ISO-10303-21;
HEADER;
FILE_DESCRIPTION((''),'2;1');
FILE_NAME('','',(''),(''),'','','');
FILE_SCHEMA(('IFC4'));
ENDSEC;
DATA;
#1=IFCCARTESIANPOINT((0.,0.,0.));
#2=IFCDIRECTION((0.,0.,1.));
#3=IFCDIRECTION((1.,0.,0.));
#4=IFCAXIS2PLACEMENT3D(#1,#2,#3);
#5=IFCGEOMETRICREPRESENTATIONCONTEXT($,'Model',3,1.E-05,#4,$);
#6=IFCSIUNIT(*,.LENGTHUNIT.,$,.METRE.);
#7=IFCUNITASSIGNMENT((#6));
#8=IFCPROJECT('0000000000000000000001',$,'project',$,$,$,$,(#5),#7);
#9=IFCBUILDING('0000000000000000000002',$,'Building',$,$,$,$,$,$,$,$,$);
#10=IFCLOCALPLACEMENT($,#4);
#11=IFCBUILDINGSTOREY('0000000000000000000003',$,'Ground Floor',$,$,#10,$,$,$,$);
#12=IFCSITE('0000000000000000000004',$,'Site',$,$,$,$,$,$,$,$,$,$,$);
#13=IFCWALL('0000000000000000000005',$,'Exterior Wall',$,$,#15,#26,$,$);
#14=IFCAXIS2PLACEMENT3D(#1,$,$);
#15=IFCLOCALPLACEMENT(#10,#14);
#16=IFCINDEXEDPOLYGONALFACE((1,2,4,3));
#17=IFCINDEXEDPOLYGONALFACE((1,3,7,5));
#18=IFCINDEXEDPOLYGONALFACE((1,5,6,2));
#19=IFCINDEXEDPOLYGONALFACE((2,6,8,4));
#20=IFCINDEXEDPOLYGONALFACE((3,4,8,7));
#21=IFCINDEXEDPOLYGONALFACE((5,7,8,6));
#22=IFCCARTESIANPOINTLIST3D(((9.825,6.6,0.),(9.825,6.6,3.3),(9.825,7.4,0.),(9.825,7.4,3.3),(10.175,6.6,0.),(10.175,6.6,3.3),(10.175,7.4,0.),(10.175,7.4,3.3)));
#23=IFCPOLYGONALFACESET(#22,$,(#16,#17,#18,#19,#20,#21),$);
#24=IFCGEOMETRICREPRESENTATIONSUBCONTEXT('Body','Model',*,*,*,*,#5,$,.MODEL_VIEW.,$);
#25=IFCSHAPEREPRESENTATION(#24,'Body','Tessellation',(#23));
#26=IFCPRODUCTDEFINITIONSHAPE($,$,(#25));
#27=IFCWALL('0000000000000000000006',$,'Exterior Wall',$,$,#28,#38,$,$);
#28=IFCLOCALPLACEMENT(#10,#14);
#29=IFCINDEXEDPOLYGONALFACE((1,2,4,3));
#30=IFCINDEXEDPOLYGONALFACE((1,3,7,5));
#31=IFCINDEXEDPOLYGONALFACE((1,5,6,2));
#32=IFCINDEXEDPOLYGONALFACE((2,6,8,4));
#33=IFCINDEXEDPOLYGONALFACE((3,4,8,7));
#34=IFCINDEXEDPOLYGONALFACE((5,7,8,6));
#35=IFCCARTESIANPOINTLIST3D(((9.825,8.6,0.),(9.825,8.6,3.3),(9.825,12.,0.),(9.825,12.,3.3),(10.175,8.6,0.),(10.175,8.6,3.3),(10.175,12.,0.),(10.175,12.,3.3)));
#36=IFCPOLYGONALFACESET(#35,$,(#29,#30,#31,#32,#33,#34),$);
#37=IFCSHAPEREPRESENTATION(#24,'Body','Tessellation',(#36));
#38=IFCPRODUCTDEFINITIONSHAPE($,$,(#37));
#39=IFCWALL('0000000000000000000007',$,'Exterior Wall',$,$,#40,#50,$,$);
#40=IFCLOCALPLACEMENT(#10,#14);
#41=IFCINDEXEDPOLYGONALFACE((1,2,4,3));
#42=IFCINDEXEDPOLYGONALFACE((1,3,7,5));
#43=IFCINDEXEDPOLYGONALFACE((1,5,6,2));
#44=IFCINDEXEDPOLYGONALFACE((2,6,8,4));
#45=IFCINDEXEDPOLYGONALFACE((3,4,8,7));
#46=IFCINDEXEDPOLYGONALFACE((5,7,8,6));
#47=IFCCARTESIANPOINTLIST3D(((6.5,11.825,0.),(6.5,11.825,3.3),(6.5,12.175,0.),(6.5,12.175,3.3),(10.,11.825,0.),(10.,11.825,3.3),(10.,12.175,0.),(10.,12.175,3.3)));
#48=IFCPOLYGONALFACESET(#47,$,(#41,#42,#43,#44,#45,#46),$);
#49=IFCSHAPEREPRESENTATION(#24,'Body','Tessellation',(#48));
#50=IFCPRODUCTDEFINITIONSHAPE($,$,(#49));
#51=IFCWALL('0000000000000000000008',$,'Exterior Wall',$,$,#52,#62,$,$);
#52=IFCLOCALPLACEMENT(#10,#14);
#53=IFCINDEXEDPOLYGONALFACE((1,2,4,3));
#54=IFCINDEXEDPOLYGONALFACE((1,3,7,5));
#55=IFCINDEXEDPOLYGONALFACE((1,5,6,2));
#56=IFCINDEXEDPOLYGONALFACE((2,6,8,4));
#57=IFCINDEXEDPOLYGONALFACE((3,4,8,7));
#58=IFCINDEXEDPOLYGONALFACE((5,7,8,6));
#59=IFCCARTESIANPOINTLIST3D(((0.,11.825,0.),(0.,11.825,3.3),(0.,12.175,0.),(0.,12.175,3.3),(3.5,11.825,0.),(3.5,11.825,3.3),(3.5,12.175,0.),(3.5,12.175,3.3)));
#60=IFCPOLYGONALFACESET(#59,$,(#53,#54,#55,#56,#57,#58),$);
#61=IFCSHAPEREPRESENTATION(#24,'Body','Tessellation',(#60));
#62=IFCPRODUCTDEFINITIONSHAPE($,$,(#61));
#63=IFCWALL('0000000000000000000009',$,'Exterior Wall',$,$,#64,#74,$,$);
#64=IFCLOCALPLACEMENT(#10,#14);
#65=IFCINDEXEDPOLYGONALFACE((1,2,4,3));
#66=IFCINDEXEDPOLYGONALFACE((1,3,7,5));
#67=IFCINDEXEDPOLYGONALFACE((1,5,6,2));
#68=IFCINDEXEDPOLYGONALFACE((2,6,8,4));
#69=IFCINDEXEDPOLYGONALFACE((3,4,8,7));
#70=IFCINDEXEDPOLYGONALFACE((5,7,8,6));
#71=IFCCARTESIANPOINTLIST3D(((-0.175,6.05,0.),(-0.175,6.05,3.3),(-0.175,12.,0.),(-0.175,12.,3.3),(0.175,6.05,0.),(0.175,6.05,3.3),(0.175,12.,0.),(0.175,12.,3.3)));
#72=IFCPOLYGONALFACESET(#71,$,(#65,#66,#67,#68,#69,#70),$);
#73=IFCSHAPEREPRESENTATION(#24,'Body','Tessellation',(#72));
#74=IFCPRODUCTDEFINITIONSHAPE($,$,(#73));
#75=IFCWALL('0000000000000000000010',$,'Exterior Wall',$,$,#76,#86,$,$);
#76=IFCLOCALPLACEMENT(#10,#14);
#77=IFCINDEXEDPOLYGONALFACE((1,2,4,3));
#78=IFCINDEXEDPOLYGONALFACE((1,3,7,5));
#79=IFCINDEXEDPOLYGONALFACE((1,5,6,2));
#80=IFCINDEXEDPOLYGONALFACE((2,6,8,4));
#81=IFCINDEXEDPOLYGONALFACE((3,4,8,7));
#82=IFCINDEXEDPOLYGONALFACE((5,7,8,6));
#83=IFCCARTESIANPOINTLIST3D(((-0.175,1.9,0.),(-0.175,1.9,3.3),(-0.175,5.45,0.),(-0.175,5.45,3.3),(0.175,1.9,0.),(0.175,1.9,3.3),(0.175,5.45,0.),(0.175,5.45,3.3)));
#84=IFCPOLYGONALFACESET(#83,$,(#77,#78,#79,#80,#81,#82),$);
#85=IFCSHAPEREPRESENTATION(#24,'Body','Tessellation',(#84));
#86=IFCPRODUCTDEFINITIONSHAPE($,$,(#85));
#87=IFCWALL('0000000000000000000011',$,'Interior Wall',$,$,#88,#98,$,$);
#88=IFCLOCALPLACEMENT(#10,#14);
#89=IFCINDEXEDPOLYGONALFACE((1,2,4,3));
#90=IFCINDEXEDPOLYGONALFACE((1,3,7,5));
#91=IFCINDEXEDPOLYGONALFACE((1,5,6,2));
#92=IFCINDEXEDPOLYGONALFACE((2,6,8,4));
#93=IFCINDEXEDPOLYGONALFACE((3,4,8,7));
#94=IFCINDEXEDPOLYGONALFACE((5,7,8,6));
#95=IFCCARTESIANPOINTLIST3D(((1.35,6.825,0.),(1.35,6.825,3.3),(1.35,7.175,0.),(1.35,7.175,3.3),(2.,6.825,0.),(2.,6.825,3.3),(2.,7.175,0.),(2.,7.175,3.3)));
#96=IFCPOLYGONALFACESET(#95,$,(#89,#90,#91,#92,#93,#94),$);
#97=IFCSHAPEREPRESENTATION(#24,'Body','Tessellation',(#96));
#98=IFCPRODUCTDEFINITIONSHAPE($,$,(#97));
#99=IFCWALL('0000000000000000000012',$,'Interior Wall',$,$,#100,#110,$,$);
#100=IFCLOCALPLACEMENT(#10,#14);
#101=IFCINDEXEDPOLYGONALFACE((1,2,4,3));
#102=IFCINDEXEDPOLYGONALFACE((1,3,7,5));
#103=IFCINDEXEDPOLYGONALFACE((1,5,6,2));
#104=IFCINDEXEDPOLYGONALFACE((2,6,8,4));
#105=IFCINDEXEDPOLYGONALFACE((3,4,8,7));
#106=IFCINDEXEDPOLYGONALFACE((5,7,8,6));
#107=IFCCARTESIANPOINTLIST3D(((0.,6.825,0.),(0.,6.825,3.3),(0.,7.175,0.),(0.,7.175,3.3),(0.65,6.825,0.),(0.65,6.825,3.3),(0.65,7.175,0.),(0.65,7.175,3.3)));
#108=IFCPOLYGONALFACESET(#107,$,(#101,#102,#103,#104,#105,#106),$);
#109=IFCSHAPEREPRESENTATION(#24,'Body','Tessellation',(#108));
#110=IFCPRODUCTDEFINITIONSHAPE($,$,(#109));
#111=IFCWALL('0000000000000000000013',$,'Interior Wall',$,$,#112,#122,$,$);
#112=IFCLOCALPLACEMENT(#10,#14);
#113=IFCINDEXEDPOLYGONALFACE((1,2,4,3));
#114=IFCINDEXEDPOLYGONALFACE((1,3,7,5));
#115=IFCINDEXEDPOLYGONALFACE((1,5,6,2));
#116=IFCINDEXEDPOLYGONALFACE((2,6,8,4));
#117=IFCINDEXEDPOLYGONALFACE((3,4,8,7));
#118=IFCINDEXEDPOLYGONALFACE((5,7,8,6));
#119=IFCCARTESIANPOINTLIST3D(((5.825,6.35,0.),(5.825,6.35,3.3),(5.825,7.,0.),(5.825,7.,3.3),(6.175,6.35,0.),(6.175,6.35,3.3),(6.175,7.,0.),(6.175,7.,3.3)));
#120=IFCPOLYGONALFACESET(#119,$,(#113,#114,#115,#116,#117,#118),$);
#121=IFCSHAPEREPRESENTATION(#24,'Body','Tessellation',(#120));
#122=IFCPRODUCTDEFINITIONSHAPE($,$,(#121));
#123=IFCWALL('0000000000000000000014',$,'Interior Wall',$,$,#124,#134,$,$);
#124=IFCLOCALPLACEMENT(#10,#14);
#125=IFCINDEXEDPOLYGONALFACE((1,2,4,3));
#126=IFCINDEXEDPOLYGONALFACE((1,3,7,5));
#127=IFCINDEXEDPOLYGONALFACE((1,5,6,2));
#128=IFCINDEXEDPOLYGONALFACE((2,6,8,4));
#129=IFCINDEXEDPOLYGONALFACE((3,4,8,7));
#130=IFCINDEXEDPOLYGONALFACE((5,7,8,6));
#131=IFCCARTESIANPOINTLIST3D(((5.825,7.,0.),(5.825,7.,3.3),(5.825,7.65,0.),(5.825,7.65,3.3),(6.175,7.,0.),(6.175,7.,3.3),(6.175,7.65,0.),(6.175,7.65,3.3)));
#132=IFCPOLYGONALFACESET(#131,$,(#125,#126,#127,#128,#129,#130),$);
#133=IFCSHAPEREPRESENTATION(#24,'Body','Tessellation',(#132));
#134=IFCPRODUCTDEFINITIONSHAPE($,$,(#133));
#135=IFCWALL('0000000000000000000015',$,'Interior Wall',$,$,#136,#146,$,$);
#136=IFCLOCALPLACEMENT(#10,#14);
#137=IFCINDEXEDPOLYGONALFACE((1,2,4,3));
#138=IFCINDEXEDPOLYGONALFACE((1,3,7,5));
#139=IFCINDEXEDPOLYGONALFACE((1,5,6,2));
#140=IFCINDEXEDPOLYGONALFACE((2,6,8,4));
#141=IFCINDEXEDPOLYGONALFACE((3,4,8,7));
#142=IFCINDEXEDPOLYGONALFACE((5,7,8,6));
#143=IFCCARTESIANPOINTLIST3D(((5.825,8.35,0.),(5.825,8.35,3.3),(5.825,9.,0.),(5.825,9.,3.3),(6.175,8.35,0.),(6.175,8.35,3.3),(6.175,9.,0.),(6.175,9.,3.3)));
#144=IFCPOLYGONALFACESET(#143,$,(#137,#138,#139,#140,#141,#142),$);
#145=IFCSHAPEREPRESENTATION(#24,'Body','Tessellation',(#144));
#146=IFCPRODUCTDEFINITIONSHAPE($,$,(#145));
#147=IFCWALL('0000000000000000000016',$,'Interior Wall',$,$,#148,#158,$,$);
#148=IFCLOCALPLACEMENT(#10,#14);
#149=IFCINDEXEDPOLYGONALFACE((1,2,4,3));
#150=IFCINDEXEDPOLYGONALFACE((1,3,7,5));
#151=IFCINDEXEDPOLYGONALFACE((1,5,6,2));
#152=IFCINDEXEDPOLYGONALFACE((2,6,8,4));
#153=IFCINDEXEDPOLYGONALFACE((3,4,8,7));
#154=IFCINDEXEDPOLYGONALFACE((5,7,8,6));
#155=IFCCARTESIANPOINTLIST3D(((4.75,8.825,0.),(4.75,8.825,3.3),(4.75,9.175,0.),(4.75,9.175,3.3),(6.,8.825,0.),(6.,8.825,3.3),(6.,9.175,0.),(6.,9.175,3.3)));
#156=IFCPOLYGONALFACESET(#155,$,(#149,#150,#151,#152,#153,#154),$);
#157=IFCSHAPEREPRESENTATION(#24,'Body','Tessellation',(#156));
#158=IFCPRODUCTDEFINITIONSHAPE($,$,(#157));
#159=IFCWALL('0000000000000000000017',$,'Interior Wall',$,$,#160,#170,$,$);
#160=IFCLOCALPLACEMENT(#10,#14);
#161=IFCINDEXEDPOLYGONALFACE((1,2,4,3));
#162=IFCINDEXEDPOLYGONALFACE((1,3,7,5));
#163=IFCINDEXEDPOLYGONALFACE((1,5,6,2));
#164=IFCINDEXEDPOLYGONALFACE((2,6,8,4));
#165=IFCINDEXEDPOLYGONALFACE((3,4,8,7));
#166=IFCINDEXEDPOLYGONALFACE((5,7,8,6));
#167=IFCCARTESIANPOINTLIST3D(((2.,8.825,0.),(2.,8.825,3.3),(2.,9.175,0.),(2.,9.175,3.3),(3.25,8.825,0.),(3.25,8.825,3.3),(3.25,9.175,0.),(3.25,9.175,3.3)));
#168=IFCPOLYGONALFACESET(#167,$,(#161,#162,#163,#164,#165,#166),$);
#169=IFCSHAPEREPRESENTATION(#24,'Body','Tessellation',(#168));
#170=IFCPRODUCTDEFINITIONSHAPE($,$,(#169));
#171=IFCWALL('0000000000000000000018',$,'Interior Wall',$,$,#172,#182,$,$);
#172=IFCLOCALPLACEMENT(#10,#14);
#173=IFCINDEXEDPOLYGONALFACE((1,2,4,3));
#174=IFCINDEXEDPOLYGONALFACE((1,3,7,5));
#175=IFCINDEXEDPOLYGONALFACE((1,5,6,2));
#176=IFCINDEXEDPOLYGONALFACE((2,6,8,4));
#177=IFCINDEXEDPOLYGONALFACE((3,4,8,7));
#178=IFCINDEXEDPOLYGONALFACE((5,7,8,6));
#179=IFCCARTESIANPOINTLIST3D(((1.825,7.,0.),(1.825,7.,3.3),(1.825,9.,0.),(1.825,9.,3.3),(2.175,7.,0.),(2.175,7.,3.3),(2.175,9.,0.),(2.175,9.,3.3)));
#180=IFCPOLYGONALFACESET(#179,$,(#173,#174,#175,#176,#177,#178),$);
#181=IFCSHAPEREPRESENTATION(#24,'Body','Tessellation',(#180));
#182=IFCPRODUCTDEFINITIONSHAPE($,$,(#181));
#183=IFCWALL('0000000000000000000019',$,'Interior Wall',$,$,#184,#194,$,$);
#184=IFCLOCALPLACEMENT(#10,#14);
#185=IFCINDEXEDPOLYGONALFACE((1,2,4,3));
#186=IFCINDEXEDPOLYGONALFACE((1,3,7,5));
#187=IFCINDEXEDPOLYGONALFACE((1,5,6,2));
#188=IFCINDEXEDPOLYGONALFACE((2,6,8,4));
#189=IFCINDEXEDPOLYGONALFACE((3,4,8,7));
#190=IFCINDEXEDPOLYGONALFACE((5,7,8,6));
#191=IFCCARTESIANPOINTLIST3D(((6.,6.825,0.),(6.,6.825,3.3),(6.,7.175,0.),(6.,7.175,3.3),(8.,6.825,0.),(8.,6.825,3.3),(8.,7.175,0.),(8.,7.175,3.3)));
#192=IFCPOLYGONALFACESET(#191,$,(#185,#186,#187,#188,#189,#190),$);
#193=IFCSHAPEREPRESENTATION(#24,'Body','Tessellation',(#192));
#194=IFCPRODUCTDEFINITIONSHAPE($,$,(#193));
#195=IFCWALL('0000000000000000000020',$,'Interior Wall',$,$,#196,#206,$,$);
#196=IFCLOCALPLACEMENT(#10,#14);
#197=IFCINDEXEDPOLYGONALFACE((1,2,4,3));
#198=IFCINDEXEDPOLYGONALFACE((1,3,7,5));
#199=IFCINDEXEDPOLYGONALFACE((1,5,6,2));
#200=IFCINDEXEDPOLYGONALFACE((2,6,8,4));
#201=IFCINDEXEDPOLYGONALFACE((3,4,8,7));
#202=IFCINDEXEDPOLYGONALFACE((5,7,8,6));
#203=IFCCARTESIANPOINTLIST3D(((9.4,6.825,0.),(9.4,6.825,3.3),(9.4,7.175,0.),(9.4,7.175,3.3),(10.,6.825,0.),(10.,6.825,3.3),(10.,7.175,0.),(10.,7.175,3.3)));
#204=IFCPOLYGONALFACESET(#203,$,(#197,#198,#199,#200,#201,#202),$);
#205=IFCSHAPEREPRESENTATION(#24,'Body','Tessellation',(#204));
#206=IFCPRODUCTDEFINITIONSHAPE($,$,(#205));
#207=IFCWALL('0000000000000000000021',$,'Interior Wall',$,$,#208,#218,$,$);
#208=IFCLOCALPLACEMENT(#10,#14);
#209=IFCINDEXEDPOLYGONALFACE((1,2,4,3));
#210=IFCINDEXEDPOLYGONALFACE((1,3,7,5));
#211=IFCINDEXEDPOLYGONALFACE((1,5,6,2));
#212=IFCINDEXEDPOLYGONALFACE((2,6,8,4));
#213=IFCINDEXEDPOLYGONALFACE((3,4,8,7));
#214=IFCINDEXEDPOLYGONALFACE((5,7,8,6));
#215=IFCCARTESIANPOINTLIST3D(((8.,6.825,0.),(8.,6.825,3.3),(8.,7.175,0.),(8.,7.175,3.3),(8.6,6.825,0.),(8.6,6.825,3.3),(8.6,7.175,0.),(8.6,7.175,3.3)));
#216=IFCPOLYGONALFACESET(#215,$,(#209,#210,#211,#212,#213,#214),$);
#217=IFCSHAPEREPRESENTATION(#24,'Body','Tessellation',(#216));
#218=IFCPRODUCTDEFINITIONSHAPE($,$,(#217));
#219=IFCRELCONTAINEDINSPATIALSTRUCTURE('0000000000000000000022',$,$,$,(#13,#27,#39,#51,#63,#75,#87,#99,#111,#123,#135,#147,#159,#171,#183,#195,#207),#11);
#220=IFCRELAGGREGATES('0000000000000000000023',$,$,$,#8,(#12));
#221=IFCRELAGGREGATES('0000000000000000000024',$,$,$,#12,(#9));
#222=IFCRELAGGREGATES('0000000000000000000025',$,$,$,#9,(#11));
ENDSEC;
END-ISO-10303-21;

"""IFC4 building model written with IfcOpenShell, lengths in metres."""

from ifc_helpers import new_model, si_unit, frame, origin_with_axes, place, context, subcontext, project, spatial, indexed_curve, outline, extrude, element, save


model = new_model("IFC4")

# Units and contexts
model_context = context("Model", 3, precision=1e-05, world=origin_with_axes())
body_context = subcontext(model_context, "Body", "Model", "MODEL_VIEW")
ifc_project = project(units=[si_unit("LENGTHUNIT", "METRE")], contexts=[model_context])

# Site, building, storey
site = spatial("IfcSite", under=ifc_project, Name="Site")
building = spatial("IfcBuilding", under=site, Name="Building")
storey_placement = place(None, origin_with_axes())
storey = spatial("IfcBuildingStorey", under=building, at=storey_placement, Name="Ground Floor")

# Walls
wall_1_placement = place(storey_placement, frame((10.0, 6.6, 0.0), z_axis=(0.0, 0.0, 1.0), x_axis=(0.0, 1.0, 0.0)))
element("IfcWall", 1, at=wall_1_placement, inside=storey, Name="Exterior Wall", context=body_context, shape_type="SweptSolid", body=[
    extrude(outline(indexed_curve([(0.0, 0.0), (0.0, 0.35), (0.8, 0.35), (0.8, 0.0), (0.0, 0.0)], self_intersect=False)), frame((0.0, -0.175, 0.0), z_axis=(0.0, 0.0, 1.0), x_axis=(1.0, 0.0, 0.0)), (0.0, 0.0, 1.0), 3.3),
])
wall_2_placement = place(storey_placement, frame((10.0, 8.6, 0.0), z_axis=(0.0, 0.0, 1.0), x_axis=(0.0, 1.0, 0.0)))
element("IfcWall", 2, at=wall_2_placement, inside=storey, Name="Exterior Wall", context=body_context, shape_type="SweptSolid", body=[
    extrude(outline(indexed_curve([(0.0, 0.0), (0.0, 0.35), (3.4, 0.35), (3.4, 0.0), (0.0, 0.0)], self_intersect=False)), frame((0.0, -0.175, 0.0), z_axis=(0.0, 0.0, 1.0), x_axis=(1.0, 0.0, 0.0)), (0.0, 0.0, 1.0), 3.3),
])
for number, where, z_axis, x_axis, name in (
    (3, (10.0, 12.0, 0.0), (0.0, 0.0, 1.0), (-1.0, 0.0, 0.0), "Exterior Wall"),
    (4, (3.5, 12.0, 0.0), (0.0, 0.0, 1.0), (-1.0, 0.0, 0.0), "Exterior Wall"),
):
    element("IfcWall", number, at=place(storey_placement, frame(where, z_axis=z_axis, x_axis=x_axis)), inside=storey, Name=name, context=body_context, shape_type="SweptSolid", body=[
        extrude(outline(indexed_curve([(0.0, 0.0), (0.0, 0.35), (3.5, 0.35), (3.5, 0.0), (0.0, 0.0)], self_intersect=False)), frame((0.0, -0.175, 0.0), z_axis=(0.0, 0.0, 1.0), x_axis=(1.0, 0.0, 0.0)), (0.0, 0.0, 1.0), 3.3),
    ])
wall_3_placement = place(storey_placement, frame((0.0, 12.0, 0.0), z_axis=(0.0, 0.0, 1.0), x_axis=(0.0, -1.0, 0.0)))
element("IfcWall", 5, at=wall_3_placement, inside=storey, Name="Exterior Wall", context=body_context, shape_type="SweptSolid", body=[
    extrude(outline(indexed_curve([(0.0, 0.0), (0.0, 0.35), (5.95, 0.35), (5.95, 0.0), (0.0, 0.0)], self_intersect=False)), frame((0.0, -0.175, 0.0), z_axis=(0.0, 0.0, 1.0), x_axis=(1.0, 0.0, 0.0)), (0.0, 0.0, 1.0), 3.3),
])
wall_4_placement = place(storey_placement, frame((0.0, 5.45, 0.0), z_axis=(0.0, 0.0, 1.0), x_axis=(0.0, -1.0, 0.0)))
element("IfcWall", 6, at=wall_4_placement, inside=storey, Name="Exterior Wall", context=body_context, shape_type="SweptSolid", body=[
    extrude(outline(indexed_curve([(0.0, 0.0), (0.0, 0.35), (3.55, 0.35), (3.55, 0.0), (0.0, 0.0)], self_intersect=False)), frame((0.0, -0.175, 0.0), z_axis=(0.0, 0.0, 1.0), x_axis=(1.0, 0.0, 0.0)), (0.0, 0.0, 1.0), 3.3),
])
for number, where, z_axis, x_axis, name in (
    (7, (2.0, 7.0, 0.0), (0.0, 0.0, 1.0), (-1.0, 0.0, 0.0), "Interior Wall"),
    (8, (0.65, 7.0, 0.0), (0.0, 0.0, 1.0), (-1.0, 0.0, 0.0), "Interior Wall"),
):
    element("IfcWall", number, at=place(storey_placement, frame(where, z_axis=z_axis, x_axis=x_axis)), inside=storey, Name=name, context=body_context, shape_type="SweptSolid", body=[
        extrude(outline(indexed_curve([(0.0, 0.0), (0.0, 0.35), (0.65, 0.35), (0.65, 0.0), (0.0, 0.0)], self_intersect=False)), frame((0.0, -0.175, 0.0), z_axis=(0.0, 0.0, 1.0), x_axis=(1.0, 0.0, 0.0)), (0.0, 0.0, 1.0), 3.3),
    ])
for number, where, z_axis, x_axis, name in (
    (9, (6.0, 6.35, 0.0), (0.0, 0.0, 1.0), (0.0, 1.0, 0.0), "Interior Wall"),
    (10, (6.0, 7.0, 0.0), (0.0, 0.0, 1.0), (0.0, 1.0, 0.0), "Interior Wall"),
    (11, (6.0, 8.35, 0.0), (0.0, 0.0, 1.0), (0.0, 1.0, 0.0), "Interior Wall"),
):
    element("IfcWall", number, at=place(storey_placement, frame(where, z_axis=z_axis, x_axis=x_axis)), inside=storey, Name=name, context=body_context, shape_type="SweptSolid", body=[
        extrude(outline(indexed_curve([(0.0, 0.0), (0.0, 0.35), (0.65, 0.35), (0.65, 0.0), (0.0, 0.0)], self_intersect=False)), frame((0.0, -0.175, 0.0), z_axis=(0.0, 0.0, 1.0), x_axis=(1.0, 0.0, 0.0)), (0.0, 0.0, 1.0), 3.3),
    ])
for number, where, z_axis, x_axis, name in (
    (12, (6.0, 9.0, 0.0), (0.0, 0.0, 1.0), (-1.0, 0.0, 0.0), "Interior Wall"),
    (13, (3.25, 9.0, 0.0), (0.0, 0.0, 1.0), (-1.0, 0.0, 0.0), "Interior Wall"),
):
    element("IfcWall", number, at=place(storey_placement, frame(where, z_axis=z_axis, x_axis=x_axis)), inside=storey, Name=name, context=body_context, shape_type="SweptSolid", body=[
        extrude(outline(indexed_curve([(0.0, 0.0), (0.0, 0.35), (1.25, 0.35), (1.25, 0.0), (0.0, 0.0)], self_intersect=False)), frame((0.0, -0.175, 0.0), z_axis=(0.0, 0.0, 1.0), x_axis=(1.0, 0.0, 0.0)), (0.0, 0.0, 1.0), 3.3),
    ])
for number, where, z_axis, x_axis, name in (
    (14, (2.0, 9.0, 0.0), (0.0, 0.0, 1.0), (0.0, -1.0, 0.0), "Interior Wall"),
    (15, (8.0, 7.0, 0.0), (0.0, 0.0, 1.0), (-1.0, 0.0, 0.0), "Interior Wall"),
):
    element("IfcWall", number, at=place(storey_placement, frame(where, z_axis=z_axis, x_axis=x_axis)), inside=storey, Name=name, context=body_context, shape_type="SweptSolid", body=[
        extrude(outline(indexed_curve([(0.0, 0.0), (0.0, 0.35), (2.0, 0.35), (2.0, 0.0), (0.0, 0.0)], self_intersect=False)), frame((0.0, -0.175, 0.0), z_axis=(0.0, 0.0, 1.0), x_axis=(1.0, 0.0, 0.0)), (0.0, 0.0, 1.0), 3.3),
    ])
for number, where, z_axis, x_axis, name in (
    (16, (10.0, 7.0, 0.0), (0.0, 0.0, 1.0), (-1.0, 0.0, 0.0), "Interior Wall"),
    (17, (8.6, 7.0, 0.0), (0.0, 0.0, 1.0), (-1.0, 0.0, 0.0), "Interior Wall"),
):
    element("IfcWall", number, at=place(storey_placement, frame(where, z_axis=z_axis, x_axis=x_axis)), inside=storey, Name=name, context=body_context, shape_type="SweptSolid", body=[
        extrude(outline(indexed_curve([(0.0, 0.0), (0.0, 0.35), (0.6, 0.35), (0.6, 0.0), (0.0, 0.0)], self_intersect=False)), frame((0.0, -0.175, 0.0), z_axis=(0.0, 0.0, 1.0), x_axis=(1.0, 0.0, 0.0)), (0.0, 0.0, 1.0), 3.3),
    ])

save(model, "model.ifc")
